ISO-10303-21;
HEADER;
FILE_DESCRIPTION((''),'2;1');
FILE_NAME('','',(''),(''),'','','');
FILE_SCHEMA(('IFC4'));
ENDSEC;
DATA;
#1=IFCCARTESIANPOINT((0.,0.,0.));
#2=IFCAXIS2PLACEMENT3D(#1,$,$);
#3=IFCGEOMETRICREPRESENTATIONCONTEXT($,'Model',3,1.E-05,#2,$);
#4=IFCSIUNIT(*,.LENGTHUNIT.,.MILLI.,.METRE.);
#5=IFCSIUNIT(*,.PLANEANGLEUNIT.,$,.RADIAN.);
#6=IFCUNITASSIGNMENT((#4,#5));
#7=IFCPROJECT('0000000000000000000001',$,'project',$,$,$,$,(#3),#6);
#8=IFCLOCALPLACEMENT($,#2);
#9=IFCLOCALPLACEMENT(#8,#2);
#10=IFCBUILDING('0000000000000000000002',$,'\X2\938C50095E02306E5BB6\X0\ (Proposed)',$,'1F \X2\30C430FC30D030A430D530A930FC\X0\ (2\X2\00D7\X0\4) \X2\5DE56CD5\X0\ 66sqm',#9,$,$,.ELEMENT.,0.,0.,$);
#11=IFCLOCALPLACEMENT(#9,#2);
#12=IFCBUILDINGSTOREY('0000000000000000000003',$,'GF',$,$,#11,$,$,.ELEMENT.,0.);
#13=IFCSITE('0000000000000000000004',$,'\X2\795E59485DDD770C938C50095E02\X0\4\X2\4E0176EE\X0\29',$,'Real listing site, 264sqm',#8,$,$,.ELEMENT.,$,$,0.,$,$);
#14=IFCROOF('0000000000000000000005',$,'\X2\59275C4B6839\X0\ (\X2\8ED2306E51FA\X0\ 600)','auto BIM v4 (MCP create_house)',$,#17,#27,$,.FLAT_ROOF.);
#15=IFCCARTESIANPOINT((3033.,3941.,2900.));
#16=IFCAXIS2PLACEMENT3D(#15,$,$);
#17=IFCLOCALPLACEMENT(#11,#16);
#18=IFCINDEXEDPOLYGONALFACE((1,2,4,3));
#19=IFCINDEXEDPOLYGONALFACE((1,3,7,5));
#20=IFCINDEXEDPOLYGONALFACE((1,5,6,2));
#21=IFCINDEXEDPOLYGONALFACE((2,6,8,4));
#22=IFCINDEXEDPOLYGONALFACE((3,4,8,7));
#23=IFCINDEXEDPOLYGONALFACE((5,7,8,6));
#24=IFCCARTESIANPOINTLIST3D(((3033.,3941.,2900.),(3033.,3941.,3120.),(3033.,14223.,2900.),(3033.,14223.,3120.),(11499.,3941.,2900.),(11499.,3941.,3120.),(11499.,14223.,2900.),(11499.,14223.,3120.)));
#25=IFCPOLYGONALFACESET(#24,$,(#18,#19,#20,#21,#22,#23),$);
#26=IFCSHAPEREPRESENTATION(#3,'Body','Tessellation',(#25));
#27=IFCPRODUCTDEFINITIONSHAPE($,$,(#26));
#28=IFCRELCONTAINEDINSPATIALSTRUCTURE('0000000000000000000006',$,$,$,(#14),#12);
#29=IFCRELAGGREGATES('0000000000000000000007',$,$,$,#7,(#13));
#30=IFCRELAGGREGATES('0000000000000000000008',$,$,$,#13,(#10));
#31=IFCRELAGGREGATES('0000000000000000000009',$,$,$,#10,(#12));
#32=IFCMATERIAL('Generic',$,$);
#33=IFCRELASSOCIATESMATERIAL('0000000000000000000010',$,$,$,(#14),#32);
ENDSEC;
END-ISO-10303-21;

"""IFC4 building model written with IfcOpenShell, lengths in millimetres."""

from ifc_helpers import new_model, si_unit, frame, frame_2d, origin, place, context, project, spatial, rectangle, extrude, material, element, save


model = new_model("IFC4")

# Units and contexts
model_context = context("Model", 3, precision=1e-05, world=origin())
ifc_project = project(units=[si_unit("LENGTHUNIT", "METRE", prefix="MILLI"), si_unit("PLANEANGLEUNIT", "RADIAN")], contexts=[model_context])

# Site, building, storey
site_placement = place(None, origin())
site = spatial("IfcSite", under=ifc_project, at=site_placement, Name="神奈川県鎌倉市4丁目29", ObjectType="Real listing site, 264sqm", CompositionType="ELEMENT", RefElevation=0.0)
building_placement = place(site_placement, origin())
building = spatial("IfcBuilding", under=site, at=building_placement, Name="鎌倉市の家 (Proposed)", ObjectType="1F ツーバイフォー (2×4) 工法 66sqm", CompositionType="ELEMENT", ElevationOfRefHeight=0.0, ElevationOfTerrain=0.0)
storey_placement = place(building_placement, origin())
storey = spatial("IfcBuildingStorey", under=building, at=storey_placement, Name="GF", CompositionType="ELEMENT", Elevation=0.0)

# Shared definitions
ifc_material = material(Name="Generic")

# Roof
roof_placement = place(storey_placement, frame((3033.0, 3941.0, 2900.0)))
element("IfcRoof", 1, at=roof_placement, inside=storey, material=ifc_material, Name="大屋根 (軒の出 600)", Description="auto BIM v4 (MCP create_house)", PredefinedType="FLAT_ROOF", context=model_context, shape_type="SweptSolid", body=[
    extrude(rectangle(XDim=8466.0, YDim=10282.0, at=frame_2d((4233.0, 5141.0))), frame((3033.0, 3941.0, 2900.0)), (0.0, 0.0, 1.0), 220.0),
])

save(model, "model.ifc")
